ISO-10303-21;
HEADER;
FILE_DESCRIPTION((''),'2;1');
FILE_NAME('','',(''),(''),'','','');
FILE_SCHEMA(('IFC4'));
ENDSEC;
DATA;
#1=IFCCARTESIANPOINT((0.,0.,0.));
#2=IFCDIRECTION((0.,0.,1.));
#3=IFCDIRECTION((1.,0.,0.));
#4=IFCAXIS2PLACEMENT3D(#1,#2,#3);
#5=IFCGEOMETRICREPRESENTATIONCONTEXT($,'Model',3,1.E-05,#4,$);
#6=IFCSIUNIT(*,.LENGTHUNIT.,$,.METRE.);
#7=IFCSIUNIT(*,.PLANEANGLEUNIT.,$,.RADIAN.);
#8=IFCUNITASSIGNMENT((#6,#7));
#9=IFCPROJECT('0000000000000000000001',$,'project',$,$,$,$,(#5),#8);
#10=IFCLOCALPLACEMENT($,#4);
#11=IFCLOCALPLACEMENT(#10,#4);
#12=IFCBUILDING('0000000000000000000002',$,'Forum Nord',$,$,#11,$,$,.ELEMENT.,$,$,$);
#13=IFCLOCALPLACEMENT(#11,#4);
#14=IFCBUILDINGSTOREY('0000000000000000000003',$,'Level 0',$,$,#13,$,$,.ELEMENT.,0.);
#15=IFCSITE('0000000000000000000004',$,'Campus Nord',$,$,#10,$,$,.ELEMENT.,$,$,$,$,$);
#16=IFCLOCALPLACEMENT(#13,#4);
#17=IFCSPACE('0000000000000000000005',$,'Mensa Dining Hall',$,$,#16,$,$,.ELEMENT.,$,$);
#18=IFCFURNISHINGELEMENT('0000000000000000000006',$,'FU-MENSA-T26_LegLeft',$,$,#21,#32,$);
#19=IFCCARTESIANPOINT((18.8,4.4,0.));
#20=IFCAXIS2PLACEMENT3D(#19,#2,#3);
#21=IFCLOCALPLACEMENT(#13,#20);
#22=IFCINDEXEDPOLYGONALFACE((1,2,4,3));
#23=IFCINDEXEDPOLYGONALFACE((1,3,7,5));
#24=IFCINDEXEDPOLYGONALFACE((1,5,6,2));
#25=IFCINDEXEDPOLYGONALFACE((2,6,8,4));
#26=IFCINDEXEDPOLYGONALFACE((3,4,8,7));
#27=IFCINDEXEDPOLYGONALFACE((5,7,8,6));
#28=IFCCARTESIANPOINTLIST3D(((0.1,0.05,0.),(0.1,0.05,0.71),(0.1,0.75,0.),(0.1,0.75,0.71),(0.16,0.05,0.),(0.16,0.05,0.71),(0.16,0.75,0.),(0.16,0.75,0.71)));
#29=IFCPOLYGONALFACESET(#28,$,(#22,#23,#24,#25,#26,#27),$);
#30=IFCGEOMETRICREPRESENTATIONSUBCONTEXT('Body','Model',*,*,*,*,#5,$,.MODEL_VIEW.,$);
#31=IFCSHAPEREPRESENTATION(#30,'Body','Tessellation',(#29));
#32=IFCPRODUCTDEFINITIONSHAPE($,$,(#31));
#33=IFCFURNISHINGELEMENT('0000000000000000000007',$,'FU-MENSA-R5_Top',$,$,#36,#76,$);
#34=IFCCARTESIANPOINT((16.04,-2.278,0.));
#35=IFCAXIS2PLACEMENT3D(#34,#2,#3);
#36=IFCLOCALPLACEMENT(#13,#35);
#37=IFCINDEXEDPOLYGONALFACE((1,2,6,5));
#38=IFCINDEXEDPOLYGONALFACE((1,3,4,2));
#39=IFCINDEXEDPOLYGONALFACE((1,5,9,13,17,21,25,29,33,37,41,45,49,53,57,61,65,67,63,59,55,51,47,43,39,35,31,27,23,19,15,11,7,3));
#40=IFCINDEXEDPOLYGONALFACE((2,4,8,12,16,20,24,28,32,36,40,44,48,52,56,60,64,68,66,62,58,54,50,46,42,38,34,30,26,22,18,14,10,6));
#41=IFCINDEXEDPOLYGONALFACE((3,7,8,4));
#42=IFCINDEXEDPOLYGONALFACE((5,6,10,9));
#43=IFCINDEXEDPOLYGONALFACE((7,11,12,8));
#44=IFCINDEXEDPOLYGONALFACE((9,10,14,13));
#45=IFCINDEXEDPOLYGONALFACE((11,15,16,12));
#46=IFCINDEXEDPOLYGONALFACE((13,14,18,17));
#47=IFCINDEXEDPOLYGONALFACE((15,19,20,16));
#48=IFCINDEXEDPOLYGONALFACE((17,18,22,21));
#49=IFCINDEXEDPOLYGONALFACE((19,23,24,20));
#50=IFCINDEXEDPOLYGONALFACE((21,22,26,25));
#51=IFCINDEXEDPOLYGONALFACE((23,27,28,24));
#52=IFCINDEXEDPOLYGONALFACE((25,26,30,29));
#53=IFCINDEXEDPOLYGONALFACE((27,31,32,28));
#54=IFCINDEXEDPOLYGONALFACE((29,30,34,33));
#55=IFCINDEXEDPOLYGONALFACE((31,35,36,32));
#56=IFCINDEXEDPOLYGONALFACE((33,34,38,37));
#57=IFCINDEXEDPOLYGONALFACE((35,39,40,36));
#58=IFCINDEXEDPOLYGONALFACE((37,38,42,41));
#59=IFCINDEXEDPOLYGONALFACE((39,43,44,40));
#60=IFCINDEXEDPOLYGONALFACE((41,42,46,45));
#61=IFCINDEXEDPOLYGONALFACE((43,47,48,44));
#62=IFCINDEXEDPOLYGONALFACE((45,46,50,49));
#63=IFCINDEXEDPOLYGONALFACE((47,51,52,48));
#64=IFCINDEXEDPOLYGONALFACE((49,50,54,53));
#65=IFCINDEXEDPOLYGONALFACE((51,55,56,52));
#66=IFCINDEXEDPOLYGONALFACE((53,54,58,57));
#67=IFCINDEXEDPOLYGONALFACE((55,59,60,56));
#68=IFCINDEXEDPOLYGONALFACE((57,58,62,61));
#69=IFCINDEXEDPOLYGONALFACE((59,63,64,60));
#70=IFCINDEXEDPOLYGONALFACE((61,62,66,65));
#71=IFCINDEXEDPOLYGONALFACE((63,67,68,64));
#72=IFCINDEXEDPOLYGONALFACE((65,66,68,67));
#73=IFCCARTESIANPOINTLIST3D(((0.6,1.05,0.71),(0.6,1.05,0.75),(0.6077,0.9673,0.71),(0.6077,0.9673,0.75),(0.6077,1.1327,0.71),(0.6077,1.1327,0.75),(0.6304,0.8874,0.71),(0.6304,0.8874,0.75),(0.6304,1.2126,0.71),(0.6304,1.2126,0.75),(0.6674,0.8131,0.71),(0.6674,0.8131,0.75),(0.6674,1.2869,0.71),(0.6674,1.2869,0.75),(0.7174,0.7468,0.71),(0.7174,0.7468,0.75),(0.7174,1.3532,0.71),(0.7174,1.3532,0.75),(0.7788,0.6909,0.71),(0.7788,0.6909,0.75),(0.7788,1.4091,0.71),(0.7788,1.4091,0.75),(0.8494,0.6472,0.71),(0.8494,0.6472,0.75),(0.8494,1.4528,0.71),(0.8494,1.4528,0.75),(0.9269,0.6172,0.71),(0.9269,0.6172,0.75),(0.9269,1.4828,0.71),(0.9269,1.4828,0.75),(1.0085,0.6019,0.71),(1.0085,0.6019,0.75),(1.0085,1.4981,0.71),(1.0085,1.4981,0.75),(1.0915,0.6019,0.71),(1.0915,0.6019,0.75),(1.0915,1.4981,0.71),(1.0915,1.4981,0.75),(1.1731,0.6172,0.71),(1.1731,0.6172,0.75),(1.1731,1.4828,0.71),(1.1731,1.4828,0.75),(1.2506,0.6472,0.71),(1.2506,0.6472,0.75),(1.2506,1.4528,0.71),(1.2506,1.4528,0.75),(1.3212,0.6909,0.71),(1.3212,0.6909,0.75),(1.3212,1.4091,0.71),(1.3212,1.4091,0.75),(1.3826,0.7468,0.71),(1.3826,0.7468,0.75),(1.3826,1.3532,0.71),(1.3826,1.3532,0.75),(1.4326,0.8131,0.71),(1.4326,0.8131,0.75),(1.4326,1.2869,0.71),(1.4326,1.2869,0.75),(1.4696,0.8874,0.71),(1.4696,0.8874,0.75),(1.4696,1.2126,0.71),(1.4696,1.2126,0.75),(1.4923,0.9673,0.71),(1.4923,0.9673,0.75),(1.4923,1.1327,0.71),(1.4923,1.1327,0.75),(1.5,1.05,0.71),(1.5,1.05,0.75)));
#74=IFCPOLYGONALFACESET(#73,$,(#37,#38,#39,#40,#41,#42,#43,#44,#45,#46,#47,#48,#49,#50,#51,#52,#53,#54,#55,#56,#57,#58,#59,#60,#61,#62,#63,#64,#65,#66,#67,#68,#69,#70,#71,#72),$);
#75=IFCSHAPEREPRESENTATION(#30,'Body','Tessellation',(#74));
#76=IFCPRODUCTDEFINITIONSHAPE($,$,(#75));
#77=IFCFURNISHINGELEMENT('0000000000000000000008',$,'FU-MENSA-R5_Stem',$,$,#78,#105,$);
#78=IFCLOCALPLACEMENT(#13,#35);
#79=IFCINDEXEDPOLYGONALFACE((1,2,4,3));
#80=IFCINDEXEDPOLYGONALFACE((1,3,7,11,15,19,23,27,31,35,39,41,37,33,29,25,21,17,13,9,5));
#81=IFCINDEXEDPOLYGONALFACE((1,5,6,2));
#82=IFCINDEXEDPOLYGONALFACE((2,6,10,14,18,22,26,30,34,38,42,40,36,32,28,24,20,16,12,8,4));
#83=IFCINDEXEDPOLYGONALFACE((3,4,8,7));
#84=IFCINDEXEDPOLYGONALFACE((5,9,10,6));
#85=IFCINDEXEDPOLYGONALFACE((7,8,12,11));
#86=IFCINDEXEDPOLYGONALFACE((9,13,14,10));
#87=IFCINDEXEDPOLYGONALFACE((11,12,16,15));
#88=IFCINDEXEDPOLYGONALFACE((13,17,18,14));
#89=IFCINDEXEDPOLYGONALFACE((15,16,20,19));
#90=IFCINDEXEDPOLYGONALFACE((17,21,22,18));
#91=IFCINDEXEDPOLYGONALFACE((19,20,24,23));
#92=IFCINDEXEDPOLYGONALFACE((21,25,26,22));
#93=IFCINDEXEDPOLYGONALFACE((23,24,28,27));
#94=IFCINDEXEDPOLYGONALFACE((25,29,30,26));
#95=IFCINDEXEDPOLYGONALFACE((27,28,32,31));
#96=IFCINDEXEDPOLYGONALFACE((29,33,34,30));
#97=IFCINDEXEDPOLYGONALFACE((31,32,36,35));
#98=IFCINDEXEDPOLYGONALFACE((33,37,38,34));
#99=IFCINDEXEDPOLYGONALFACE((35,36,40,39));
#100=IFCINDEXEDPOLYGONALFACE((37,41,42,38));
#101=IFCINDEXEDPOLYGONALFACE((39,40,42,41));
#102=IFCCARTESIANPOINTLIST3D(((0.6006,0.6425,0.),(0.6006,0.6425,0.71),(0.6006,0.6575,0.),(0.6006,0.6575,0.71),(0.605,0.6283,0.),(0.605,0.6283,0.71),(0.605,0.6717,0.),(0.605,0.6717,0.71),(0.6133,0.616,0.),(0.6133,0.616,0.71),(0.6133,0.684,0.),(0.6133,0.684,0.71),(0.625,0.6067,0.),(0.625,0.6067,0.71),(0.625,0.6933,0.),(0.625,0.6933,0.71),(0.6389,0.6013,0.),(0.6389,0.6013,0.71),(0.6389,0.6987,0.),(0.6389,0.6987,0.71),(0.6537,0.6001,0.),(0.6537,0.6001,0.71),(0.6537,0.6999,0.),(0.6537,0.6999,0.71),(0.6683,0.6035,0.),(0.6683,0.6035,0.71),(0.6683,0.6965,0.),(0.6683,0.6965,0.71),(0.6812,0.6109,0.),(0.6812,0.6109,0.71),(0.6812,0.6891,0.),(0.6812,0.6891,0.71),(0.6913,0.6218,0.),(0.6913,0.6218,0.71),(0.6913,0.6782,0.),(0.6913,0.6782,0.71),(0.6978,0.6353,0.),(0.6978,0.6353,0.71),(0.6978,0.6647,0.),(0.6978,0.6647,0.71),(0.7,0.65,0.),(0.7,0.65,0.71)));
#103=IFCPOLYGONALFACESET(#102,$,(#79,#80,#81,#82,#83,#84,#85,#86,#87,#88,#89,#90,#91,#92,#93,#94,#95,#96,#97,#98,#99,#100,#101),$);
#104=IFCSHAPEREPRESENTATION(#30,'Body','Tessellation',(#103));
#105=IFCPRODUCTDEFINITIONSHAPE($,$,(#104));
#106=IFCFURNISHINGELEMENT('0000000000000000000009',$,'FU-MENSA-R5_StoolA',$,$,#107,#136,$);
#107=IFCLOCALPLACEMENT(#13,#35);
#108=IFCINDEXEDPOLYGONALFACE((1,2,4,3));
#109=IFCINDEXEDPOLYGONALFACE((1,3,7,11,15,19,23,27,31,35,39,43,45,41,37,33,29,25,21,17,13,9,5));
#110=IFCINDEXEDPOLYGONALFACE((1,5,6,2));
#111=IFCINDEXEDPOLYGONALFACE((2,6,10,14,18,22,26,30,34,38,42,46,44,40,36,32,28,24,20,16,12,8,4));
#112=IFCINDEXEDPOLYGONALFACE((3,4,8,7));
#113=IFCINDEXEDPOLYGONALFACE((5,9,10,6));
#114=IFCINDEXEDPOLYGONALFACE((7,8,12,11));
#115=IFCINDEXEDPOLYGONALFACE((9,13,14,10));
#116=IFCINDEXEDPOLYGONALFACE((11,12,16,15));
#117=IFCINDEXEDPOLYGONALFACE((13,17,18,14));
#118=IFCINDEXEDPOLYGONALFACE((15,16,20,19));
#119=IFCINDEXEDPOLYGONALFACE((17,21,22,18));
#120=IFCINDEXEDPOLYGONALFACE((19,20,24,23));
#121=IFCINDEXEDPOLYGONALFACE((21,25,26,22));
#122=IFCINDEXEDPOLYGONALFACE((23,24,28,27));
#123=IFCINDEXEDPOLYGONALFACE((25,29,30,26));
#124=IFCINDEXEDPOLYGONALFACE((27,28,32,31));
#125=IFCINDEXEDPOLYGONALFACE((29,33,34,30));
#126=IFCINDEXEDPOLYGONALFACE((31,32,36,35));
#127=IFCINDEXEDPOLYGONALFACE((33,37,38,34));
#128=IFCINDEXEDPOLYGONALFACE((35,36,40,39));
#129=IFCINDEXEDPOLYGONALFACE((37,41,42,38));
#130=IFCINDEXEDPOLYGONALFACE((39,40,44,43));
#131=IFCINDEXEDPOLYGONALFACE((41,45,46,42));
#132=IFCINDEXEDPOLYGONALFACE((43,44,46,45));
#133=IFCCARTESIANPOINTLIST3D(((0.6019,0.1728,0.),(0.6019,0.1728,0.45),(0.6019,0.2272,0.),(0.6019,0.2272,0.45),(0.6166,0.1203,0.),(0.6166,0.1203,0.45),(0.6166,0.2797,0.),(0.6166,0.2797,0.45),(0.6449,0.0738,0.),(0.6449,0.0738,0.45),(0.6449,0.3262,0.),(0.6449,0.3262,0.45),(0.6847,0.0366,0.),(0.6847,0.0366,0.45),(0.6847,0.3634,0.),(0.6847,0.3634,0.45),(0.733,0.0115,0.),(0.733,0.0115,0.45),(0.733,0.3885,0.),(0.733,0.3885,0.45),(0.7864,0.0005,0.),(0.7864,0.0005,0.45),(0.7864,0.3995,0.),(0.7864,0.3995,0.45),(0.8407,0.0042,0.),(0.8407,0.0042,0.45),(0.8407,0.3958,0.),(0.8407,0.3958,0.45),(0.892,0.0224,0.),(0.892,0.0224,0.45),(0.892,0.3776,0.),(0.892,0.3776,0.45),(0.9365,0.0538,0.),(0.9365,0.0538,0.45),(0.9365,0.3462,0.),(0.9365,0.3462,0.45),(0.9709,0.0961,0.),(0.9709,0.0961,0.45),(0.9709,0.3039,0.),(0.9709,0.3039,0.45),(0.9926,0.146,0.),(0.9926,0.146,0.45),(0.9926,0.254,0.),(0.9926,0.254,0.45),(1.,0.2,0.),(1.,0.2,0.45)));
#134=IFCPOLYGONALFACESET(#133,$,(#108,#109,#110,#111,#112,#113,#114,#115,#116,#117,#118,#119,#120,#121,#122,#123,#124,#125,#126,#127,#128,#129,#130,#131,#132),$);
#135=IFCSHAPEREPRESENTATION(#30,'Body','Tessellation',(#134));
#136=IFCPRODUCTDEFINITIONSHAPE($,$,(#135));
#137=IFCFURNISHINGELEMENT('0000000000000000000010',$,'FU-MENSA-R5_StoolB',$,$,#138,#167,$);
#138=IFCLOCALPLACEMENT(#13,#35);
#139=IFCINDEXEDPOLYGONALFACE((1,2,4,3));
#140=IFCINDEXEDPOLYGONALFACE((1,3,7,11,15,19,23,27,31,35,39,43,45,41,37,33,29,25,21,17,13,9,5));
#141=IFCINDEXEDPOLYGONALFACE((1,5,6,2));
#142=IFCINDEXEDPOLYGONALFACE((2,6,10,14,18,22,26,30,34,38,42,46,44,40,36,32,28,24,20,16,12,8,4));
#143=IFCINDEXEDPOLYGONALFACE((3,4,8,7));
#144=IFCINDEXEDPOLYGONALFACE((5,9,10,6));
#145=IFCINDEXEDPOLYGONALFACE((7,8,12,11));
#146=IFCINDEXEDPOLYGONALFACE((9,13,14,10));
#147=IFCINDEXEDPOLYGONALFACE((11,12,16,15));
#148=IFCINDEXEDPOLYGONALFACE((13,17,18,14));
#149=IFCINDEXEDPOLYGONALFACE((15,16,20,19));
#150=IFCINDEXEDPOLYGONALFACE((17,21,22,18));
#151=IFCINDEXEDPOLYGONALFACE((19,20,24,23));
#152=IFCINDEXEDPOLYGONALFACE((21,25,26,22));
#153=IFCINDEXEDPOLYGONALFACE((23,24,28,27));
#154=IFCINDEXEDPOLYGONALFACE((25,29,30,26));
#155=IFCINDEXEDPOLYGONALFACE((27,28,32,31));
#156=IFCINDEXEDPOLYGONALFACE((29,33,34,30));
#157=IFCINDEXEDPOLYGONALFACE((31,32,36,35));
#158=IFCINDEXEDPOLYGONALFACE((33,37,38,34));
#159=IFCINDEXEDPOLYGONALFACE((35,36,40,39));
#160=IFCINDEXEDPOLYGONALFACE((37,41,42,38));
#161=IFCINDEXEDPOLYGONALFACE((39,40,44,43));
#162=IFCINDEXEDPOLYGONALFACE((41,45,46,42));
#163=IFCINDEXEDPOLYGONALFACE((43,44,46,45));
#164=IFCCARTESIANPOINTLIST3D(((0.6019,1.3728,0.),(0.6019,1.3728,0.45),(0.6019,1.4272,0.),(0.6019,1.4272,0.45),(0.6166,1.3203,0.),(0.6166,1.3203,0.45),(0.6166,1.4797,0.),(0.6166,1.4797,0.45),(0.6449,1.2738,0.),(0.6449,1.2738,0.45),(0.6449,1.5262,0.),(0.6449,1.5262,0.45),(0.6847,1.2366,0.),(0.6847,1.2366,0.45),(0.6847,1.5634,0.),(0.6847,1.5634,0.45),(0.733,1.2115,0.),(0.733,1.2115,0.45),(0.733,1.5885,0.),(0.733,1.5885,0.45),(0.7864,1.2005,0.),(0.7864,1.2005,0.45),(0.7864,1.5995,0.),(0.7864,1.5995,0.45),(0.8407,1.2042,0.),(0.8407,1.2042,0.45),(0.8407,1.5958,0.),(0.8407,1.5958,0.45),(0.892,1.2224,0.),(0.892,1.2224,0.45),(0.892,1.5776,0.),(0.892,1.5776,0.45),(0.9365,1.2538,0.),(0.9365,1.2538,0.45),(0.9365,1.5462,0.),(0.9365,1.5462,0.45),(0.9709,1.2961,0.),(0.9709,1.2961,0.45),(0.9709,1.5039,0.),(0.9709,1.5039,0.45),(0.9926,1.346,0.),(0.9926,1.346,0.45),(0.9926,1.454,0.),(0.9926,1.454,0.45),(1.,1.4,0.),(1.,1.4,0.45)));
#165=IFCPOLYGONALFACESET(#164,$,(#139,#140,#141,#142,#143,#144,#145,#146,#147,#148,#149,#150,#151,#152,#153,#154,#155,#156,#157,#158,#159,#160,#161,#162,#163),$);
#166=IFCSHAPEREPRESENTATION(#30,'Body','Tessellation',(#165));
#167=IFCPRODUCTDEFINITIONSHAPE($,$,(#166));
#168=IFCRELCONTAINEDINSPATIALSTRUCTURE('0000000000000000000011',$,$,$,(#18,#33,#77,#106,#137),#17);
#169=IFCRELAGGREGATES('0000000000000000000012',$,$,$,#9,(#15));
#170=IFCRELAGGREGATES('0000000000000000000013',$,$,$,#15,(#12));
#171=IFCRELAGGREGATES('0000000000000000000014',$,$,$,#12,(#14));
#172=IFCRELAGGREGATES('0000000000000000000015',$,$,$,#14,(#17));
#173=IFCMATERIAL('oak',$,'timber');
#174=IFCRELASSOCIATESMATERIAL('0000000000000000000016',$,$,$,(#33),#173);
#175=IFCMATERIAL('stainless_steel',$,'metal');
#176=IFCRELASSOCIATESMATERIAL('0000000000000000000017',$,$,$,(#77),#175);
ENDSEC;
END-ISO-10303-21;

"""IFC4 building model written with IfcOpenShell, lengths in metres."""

from ifc_helpers import new_model, si_unit, frame, frame_2d, origin_with_axes, place, context, subcontext, project, spatial, rectangle, circle, extrude, material, element, save


model = new_model("IFC4")

# Units and contexts
model_context = context("Model", 3, precision=1e-05, world=origin_with_axes())
body_context = subcontext(model_context, "Body", "Model", "MODEL_VIEW")
ifc_project = project(units=[si_unit("LENGTHUNIT", "METRE"), si_unit("PLANEANGLEUNIT", "RADIAN")], contexts=[model_context])

# Site, building, storey
site_placement = place(None, origin_with_axes())
site = spatial("IfcSite", under=ifc_project, at=site_placement, Name="Campus Nord", CompositionType="ELEMENT")
building_placement = place(site_placement, origin_with_axes())
building = spatial("IfcBuilding", under=site, at=building_placement, Name="Forum Nord", CompositionType="ELEMENT")
storey_placement = place(building_placement, origin_with_axes())
storey = spatial("IfcBuildingStorey", under=building, at=storey_placement, Name="Level 0", CompositionType="ELEMENT", Elevation=0.0)

# Shared definitions
space_placement = place(storey_placement, origin_with_axes())
space = spatial("IfcSpace", under=storey, at=space_placement, Name="Mensa Dining Hall", CompositionType="ELEMENT")

# Furnishing elements
ifc_material_1 = material(Name="oak", Category="timber")
furnishing_1_placement = place(storey_placement, frame((18.8, 4.4, 0.0), z_axis=(0.0, 0.0, 1.0), x_axis=(1.0, 0.0, 0.0)))
element("IfcFurnishingElement", 1, at=furnishing_1_placement, inside=space, Name="FU-MENSA-T26_LegLeft", context=body_context, shape_type="SweptSolid", body=[
    extrude(rectangle(XDim=0.06, YDim=0.7, at=frame_2d((0.13, 0.4), x_axis=(1.0, 0.0))), origin_with_axes(), (0.0, 0.0, 1.0), 0.71),
])
furnishing_2_placement = place(storey_placement, frame((16.04, -2.278, 0.0), z_axis=(0.0, 0.0, 1.0), x_axis=(1.0, 0.0, 0.0)))
element("IfcFurnishingElement", 2, at=furnishing_2_placement, inside=space, material=ifc_material_1, Name="FU-MENSA-R5_Top", context=body_context, shape_type="SweptSolid", body=[
    extrude(circle(Radius=0.45, at=frame_2d((1.05, 1.05), x_axis=(1.0, 0.0))), frame((0.0, 0.0, 0.71), z_axis=(0.0, 0.0, 1.0), x_axis=(1.0, 0.0, 0.0)), (0.0, 0.0, 1.0), 0.04),
])
ifc_material_2 = material(Name="stainless_steel", Category="metal")
furnishing_3_placement = place(storey_placement, frame((16.04, -2.278, 0.0), z_axis=(0.0, 0.0, 1.0), x_axis=(1.0, 0.0, 0.0)))
element("IfcFurnishingElement", 3, at=furnishing_3_placement, inside=space, material=ifc_material_2, Name="FU-MENSA-R5_Stem", context=body_context, shape_type="SweptSolid", body=[
    extrude(circle(Radius=0.05, at=frame_2d((0.65, 0.65), x_axis=(1.0, 0.0))), origin_with_axes(), (0.0, 0.0, 1.0), 0.71),
])
furnishing_4_placement = place(storey_placement, frame((16.04, -2.278, 0.0), z_axis=(0.0, 0.0, 1.0), x_axis=(1.0, 0.0, 0.0)))
element("IfcFurnishingElement", 4, at=furnishing_4_placement, inside=space, Name="FU-MENSA-R5_StoolA", context=body_context, shape_type="SweptSolid", body=[
    extrude(circle(Radius=0.2, at=frame_2d((0.8, 0.2), x_axis=(1.0, 0.0))), origin_with_axes(), (0.0, 0.0, 1.0), 0.45),
])
furnishing_5_placement = place(storey_placement, frame((16.04, -2.278, 0.0), z_axis=(0.0, 0.0, 1.0), x_axis=(1.0, 0.0, 0.0)))
element("IfcFurnishingElement", 5, at=furnishing_5_placement, inside=space, Name="FU-MENSA-R5_StoolB", context=body_context, shape_type="SweptSolid", body=[
    extrude(circle(Radius=0.2, at=frame_2d((0.8, 1.4), x_axis=(1.0, 0.0))), origin_with_axes(), (0.0, 0.0, 1.0), 0.45),
])

save(model, "model.ifc")
